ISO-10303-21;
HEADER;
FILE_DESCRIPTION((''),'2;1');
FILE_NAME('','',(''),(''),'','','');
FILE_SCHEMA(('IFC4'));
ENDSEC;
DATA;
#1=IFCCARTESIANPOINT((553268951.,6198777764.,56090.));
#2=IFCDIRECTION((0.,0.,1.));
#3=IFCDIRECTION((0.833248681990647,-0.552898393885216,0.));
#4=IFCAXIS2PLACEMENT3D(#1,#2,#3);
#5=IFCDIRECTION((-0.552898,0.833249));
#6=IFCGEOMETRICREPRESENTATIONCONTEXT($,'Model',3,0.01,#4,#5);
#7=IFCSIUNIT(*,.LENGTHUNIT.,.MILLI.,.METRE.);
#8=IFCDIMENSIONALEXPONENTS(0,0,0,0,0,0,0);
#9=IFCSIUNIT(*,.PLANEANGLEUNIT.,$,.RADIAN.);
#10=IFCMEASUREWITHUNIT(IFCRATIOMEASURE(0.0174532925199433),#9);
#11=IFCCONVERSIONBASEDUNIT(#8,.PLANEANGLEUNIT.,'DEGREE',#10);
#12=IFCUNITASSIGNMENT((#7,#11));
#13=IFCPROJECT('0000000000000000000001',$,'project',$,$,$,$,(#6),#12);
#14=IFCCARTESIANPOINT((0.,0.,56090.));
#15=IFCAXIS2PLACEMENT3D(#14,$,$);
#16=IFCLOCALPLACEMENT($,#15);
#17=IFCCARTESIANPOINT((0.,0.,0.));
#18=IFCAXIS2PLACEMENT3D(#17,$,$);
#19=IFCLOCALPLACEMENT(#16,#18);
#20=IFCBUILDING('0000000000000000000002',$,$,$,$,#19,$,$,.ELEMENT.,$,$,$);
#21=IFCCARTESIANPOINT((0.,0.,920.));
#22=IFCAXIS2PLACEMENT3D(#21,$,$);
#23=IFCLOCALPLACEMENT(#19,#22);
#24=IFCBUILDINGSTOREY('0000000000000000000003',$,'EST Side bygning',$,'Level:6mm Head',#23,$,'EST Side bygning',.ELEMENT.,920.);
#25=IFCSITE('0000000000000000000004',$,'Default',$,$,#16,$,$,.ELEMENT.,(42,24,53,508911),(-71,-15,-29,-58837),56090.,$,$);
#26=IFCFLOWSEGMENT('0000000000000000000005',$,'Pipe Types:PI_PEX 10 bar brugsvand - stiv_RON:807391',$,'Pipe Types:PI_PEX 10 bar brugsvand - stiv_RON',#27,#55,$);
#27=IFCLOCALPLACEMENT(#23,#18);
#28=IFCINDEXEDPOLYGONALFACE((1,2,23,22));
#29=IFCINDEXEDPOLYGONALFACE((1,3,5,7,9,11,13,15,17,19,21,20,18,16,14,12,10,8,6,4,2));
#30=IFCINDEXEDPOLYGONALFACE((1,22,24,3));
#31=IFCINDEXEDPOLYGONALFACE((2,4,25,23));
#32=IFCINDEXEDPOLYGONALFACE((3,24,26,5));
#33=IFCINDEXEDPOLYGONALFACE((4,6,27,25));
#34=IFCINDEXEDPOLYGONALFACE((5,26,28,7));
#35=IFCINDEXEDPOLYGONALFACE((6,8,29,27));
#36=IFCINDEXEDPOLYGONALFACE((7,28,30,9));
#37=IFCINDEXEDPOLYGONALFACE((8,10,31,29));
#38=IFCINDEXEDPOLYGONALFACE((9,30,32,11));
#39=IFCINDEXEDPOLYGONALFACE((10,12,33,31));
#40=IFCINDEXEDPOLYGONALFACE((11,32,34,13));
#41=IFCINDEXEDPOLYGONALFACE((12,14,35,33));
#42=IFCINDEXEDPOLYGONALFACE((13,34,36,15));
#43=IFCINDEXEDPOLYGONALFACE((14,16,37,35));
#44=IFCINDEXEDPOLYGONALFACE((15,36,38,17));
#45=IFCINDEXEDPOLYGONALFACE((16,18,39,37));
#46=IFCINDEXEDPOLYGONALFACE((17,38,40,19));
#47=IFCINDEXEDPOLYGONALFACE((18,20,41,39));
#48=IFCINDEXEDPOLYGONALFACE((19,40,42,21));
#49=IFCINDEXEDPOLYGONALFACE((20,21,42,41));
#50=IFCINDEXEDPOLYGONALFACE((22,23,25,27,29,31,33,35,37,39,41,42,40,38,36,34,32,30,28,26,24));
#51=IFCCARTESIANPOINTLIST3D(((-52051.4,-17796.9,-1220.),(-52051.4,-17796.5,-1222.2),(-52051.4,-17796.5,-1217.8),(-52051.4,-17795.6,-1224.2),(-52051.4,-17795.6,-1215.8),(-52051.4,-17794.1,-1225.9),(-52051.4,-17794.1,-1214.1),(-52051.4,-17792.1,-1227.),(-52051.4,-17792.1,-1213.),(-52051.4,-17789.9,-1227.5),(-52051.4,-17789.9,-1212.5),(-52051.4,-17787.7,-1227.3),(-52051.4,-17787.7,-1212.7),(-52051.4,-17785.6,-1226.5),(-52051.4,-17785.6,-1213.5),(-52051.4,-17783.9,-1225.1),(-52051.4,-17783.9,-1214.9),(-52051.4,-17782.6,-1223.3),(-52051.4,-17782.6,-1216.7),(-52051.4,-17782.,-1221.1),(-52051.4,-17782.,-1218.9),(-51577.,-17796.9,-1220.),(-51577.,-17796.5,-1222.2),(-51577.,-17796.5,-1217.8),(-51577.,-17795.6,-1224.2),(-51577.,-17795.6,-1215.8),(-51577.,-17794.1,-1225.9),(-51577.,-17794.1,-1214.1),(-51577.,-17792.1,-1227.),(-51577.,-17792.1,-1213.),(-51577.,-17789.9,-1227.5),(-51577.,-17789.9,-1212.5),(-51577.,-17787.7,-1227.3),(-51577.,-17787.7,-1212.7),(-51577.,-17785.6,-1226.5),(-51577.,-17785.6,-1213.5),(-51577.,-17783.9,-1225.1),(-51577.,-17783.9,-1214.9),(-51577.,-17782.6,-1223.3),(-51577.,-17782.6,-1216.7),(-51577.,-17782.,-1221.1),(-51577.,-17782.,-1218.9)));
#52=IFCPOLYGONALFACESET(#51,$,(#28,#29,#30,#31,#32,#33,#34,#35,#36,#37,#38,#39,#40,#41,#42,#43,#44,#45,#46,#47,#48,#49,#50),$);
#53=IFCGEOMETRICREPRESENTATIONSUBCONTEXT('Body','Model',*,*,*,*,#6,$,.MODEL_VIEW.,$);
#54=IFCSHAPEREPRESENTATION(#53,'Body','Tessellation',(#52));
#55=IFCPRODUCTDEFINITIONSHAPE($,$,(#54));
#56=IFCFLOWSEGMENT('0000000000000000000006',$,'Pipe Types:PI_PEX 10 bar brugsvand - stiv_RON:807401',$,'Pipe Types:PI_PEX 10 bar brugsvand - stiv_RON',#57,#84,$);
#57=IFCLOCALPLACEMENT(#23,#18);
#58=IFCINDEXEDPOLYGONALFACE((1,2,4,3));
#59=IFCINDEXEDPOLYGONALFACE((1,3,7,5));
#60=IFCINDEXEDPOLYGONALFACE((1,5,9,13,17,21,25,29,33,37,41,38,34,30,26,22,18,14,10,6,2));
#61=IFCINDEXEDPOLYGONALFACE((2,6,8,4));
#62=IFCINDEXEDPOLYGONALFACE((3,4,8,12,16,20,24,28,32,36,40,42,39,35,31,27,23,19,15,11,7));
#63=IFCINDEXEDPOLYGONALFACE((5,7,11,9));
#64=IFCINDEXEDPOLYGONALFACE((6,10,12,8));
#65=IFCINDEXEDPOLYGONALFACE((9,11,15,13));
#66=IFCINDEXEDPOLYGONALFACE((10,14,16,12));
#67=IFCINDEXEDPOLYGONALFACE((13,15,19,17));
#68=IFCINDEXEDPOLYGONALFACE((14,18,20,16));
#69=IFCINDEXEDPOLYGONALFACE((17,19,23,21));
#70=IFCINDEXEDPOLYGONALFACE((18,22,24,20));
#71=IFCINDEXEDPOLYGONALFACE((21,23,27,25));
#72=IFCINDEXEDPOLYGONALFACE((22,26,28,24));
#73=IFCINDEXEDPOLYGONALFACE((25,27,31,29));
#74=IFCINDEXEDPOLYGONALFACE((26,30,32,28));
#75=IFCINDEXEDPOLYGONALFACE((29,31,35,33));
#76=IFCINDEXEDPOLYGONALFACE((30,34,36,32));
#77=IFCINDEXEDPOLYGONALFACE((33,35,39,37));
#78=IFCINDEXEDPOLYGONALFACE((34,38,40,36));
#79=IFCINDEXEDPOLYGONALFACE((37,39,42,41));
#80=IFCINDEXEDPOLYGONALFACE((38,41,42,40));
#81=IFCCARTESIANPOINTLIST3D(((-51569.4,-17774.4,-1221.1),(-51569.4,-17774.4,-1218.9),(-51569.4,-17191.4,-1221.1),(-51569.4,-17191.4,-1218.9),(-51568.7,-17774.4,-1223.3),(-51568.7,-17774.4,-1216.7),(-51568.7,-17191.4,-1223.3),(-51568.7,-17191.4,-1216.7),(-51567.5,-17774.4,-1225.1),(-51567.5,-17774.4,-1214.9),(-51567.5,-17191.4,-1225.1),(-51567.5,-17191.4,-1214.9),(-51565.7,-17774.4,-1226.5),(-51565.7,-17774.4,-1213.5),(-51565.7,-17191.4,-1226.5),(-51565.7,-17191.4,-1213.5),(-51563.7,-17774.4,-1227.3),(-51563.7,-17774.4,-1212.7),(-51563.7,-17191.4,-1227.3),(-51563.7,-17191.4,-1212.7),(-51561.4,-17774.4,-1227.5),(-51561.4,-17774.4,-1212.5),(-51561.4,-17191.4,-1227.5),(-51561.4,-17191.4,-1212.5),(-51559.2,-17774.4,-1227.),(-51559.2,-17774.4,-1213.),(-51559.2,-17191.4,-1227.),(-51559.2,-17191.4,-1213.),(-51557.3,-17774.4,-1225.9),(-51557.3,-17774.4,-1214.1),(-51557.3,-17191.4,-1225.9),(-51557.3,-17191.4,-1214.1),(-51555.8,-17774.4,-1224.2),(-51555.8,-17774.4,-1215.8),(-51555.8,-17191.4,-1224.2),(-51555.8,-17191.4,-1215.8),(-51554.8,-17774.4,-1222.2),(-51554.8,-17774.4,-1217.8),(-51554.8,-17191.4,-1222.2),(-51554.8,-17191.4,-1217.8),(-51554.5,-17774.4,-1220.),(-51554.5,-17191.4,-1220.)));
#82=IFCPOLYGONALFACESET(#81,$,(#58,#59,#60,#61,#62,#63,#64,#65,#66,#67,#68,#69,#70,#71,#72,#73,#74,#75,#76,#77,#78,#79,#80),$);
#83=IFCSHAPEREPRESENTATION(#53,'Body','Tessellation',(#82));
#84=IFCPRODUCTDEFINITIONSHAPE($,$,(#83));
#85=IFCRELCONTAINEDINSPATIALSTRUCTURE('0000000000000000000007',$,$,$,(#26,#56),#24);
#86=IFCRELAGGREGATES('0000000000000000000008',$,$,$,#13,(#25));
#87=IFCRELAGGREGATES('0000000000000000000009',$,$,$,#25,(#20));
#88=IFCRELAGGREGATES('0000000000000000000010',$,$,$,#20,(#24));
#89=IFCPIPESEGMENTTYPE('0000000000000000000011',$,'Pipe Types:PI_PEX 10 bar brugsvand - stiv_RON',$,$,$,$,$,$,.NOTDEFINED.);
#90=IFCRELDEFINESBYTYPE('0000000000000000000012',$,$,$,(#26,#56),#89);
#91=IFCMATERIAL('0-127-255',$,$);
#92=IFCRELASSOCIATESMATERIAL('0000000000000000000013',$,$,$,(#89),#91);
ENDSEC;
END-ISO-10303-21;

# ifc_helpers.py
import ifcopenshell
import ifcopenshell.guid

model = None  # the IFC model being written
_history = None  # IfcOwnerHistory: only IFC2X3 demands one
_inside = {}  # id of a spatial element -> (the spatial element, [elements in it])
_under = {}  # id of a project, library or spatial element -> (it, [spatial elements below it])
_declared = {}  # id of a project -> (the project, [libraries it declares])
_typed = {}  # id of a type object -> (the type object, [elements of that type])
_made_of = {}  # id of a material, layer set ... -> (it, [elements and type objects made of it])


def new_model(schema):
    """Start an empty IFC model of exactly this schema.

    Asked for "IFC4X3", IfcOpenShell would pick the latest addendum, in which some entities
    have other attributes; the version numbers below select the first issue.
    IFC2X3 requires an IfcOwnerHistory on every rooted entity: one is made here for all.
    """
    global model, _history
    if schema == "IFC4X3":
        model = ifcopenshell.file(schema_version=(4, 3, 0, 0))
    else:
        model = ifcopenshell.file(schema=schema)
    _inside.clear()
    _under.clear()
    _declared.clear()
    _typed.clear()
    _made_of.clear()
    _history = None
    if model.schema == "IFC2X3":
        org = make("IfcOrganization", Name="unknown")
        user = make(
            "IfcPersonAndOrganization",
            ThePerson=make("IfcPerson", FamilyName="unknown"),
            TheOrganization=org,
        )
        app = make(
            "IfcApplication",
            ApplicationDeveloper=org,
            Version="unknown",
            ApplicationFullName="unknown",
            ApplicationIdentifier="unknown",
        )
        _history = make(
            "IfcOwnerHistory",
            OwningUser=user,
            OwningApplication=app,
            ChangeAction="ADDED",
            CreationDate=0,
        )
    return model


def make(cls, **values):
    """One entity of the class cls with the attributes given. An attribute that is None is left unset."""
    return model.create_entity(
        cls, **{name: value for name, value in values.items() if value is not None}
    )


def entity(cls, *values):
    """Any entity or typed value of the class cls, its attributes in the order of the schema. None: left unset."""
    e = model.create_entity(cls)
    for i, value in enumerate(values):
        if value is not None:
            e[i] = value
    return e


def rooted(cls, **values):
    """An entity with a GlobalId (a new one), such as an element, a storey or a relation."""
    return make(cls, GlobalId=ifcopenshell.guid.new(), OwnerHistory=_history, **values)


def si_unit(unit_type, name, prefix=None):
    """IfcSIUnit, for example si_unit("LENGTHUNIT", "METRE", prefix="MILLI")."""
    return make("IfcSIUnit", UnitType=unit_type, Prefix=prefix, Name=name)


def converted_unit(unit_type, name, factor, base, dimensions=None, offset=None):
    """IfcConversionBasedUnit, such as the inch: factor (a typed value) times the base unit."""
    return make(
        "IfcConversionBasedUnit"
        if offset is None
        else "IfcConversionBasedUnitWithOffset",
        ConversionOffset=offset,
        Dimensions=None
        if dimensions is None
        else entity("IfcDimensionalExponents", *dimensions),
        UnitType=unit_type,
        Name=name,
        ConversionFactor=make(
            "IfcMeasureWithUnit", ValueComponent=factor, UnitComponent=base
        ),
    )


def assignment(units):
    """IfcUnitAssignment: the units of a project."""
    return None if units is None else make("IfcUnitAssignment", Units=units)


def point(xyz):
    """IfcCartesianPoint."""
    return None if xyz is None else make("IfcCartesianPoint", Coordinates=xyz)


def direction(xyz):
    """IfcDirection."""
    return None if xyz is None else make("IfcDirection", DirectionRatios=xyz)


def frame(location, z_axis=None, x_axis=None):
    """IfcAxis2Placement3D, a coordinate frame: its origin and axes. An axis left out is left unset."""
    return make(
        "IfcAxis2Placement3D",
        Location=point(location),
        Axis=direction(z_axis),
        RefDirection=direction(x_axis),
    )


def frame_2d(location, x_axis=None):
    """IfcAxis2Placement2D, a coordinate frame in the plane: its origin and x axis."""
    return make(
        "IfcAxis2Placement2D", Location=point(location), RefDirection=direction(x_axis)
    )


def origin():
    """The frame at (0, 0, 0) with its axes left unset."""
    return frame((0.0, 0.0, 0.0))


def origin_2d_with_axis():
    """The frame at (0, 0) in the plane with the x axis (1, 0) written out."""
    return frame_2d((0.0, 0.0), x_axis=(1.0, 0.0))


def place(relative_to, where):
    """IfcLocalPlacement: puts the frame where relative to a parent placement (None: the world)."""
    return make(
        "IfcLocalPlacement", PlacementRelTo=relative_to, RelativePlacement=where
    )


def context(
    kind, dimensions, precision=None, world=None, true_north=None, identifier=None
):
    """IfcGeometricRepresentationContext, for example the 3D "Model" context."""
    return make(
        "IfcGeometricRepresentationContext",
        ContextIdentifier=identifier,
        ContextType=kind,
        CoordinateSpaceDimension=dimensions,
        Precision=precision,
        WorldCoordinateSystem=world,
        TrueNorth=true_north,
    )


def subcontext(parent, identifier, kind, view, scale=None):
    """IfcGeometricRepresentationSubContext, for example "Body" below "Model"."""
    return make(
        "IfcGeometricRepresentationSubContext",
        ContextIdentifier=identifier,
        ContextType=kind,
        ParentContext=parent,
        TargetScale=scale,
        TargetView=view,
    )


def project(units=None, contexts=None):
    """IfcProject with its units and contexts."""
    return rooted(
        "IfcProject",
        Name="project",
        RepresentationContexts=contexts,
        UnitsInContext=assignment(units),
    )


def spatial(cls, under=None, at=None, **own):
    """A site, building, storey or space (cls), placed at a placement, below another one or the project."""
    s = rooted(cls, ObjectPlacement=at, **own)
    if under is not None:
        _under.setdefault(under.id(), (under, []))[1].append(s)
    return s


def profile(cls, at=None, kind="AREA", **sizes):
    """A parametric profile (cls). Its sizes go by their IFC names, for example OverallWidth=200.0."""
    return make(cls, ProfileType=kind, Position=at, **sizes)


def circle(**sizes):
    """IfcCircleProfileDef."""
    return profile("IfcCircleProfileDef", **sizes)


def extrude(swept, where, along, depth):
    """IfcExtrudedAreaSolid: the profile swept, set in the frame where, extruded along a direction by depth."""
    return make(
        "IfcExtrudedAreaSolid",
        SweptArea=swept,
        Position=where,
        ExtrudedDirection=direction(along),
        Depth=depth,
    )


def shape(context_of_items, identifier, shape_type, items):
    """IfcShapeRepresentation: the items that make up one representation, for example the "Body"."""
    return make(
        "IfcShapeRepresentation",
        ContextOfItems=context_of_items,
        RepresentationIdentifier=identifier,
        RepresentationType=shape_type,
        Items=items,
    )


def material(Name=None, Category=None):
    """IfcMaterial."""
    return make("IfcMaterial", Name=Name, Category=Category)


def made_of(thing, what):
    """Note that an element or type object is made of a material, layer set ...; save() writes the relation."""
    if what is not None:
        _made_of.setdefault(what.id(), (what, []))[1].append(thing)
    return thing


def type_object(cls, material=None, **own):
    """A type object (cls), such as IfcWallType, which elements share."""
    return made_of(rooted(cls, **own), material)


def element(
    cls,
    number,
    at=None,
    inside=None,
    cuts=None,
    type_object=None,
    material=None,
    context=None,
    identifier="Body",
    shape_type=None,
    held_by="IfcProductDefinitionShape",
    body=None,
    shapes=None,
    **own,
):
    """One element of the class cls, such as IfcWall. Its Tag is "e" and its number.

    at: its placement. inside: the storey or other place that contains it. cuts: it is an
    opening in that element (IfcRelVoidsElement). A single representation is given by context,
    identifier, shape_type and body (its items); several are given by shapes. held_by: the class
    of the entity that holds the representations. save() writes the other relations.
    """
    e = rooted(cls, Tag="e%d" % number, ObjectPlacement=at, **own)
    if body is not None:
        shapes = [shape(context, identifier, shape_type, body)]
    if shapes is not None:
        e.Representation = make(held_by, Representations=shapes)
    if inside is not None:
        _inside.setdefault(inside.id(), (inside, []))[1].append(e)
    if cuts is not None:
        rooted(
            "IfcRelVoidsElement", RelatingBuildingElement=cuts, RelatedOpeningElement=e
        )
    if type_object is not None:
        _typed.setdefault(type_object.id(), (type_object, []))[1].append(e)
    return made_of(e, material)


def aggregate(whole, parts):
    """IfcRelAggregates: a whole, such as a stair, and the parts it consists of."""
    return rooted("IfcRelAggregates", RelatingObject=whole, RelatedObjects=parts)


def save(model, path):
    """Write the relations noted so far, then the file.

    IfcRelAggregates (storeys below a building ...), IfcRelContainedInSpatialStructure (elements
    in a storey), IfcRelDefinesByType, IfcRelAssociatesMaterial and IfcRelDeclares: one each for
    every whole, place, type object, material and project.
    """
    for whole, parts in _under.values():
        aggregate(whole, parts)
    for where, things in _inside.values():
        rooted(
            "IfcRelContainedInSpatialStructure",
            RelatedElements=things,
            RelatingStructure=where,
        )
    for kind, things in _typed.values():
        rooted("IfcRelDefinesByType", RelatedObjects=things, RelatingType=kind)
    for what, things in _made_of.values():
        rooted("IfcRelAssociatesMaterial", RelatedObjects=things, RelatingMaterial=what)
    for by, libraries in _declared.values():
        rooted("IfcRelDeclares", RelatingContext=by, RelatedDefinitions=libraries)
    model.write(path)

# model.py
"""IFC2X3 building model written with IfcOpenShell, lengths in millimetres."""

from ifc_helpers import new_model, entity, si_unit, converted_unit, direction, frame, origin, origin_2d_with_axis, place, context, subcontext, project, spatial, circle, extrude, material, type_object, element, save


model = new_model("IFC2X3")

# Units and contexts
model_context = context("Model", 3, precision=0.01, world=frame((553268951.0, 6198777764.0, 56090.0), z_axis=(0.0, 0.0, 1.0), x_axis=(0.833248681990647, -0.552898393885216, 0.0)), true_north=direction((-0.552898, 0.833249)))
body_context = subcontext(model_context, "Body", "Model", "MODEL_VIEW")
ifc_project = project(units=[si_unit("LENGTHUNIT", "METRE", prefix="MILLI"), converted_unit("PLANEANGLEUNIT", "DEGREE", entity("IfcRatioMeasure", 0.0174532925199433), si_unit("PLANEANGLEUNIT", "RADIAN"), dimensions=[0, 0, 0, 0, 0, 0, 0])], contexts=[model_context])

# Site, building, storey
site_placement = place(None, frame((0.0, 0.0, 56090.0)))
site = spatial("IfcSite", under=ifc_project, at=site_placement, Name="Default", CompositionType="ELEMENT", RefLatitude=(42, 24, 53, 508911), RefLongitude=(-71, -15, -29, -58837), RefElevation=56090.0)
building_placement = place(site_placement, origin())
building = spatial("IfcBuilding", under=site, at=building_placement, CompositionType="ELEMENT")
storey_placement = place(building_placement, frame((0.0, 0.0, 920.0)))
storey = spatial("IfcBuildingStorey", under=building, at=storey_placement, Name="EST Side bygning", ObjectType="Level:6mm Head", LongName="EST Side bygning", CompositionType="ELEMENT", Elevation=920.0)

# Flow segments
ifc_material_1 = material(Name="0-127-255")
pipe_segment_type_1 = type_object("IfcPipeSegmentType", Name="Pipe Types:PI_PEX 10 bar brugsvand - stiv_RON", PredefinedType="NOTDEFINED", material=ifc_material_1)
flow_segment_1_placement = place(storey_placement, origin())
element("IfcFlowSegment", 1, at=flow_segment_1_placement, inside=storey, type_object=pipe_segment_type_1, Name="Pipe Types:PI_PEX 10 bar brugsvand - stiv_RON:807391", ObjectType="Pipe Types:PI_PEX 10 bar brugsvand - stiv_RON", context=body_context, shape_type="SweptSolid", body=[
    extrude(circle(Radius=7.5, at=origin_2d_with_axis()), frame((-52051.4, -17789.4, -1220.0), z_axis=(1.0, 0.0, 0.0), x_axis=(0.0, -1.0, 0.0)), (0.0, 0.0, 1.0), 474.4),
])
flow_segment_2_placement = place(storey_placement, origin())
element("IfcFlowSegment", 2, at=flow_segment_2_placement, inside=storey, type_object=pipe_segment_type_1, Name="Pipe Types:PI_PEX 10 bar brugsvand - stiv_RON:807401", ObjectType="Pipe Types:PI_PEX 10 bar brugsvand - stiv_RON", context=body_context, shape_type="SweptSolid", body=[
    extrude(circle(Radius=7.5, at=origin_2d_with_axis()), frame((-51562.0, -17774.4, -1220.0), z_axis=(0.0, 1.0, 0.0), x_axis=(1.0, 0.0, 0.0)), (0.0, 0.0, 1.0), 583.0),
])

save(model, "model.ifc")
